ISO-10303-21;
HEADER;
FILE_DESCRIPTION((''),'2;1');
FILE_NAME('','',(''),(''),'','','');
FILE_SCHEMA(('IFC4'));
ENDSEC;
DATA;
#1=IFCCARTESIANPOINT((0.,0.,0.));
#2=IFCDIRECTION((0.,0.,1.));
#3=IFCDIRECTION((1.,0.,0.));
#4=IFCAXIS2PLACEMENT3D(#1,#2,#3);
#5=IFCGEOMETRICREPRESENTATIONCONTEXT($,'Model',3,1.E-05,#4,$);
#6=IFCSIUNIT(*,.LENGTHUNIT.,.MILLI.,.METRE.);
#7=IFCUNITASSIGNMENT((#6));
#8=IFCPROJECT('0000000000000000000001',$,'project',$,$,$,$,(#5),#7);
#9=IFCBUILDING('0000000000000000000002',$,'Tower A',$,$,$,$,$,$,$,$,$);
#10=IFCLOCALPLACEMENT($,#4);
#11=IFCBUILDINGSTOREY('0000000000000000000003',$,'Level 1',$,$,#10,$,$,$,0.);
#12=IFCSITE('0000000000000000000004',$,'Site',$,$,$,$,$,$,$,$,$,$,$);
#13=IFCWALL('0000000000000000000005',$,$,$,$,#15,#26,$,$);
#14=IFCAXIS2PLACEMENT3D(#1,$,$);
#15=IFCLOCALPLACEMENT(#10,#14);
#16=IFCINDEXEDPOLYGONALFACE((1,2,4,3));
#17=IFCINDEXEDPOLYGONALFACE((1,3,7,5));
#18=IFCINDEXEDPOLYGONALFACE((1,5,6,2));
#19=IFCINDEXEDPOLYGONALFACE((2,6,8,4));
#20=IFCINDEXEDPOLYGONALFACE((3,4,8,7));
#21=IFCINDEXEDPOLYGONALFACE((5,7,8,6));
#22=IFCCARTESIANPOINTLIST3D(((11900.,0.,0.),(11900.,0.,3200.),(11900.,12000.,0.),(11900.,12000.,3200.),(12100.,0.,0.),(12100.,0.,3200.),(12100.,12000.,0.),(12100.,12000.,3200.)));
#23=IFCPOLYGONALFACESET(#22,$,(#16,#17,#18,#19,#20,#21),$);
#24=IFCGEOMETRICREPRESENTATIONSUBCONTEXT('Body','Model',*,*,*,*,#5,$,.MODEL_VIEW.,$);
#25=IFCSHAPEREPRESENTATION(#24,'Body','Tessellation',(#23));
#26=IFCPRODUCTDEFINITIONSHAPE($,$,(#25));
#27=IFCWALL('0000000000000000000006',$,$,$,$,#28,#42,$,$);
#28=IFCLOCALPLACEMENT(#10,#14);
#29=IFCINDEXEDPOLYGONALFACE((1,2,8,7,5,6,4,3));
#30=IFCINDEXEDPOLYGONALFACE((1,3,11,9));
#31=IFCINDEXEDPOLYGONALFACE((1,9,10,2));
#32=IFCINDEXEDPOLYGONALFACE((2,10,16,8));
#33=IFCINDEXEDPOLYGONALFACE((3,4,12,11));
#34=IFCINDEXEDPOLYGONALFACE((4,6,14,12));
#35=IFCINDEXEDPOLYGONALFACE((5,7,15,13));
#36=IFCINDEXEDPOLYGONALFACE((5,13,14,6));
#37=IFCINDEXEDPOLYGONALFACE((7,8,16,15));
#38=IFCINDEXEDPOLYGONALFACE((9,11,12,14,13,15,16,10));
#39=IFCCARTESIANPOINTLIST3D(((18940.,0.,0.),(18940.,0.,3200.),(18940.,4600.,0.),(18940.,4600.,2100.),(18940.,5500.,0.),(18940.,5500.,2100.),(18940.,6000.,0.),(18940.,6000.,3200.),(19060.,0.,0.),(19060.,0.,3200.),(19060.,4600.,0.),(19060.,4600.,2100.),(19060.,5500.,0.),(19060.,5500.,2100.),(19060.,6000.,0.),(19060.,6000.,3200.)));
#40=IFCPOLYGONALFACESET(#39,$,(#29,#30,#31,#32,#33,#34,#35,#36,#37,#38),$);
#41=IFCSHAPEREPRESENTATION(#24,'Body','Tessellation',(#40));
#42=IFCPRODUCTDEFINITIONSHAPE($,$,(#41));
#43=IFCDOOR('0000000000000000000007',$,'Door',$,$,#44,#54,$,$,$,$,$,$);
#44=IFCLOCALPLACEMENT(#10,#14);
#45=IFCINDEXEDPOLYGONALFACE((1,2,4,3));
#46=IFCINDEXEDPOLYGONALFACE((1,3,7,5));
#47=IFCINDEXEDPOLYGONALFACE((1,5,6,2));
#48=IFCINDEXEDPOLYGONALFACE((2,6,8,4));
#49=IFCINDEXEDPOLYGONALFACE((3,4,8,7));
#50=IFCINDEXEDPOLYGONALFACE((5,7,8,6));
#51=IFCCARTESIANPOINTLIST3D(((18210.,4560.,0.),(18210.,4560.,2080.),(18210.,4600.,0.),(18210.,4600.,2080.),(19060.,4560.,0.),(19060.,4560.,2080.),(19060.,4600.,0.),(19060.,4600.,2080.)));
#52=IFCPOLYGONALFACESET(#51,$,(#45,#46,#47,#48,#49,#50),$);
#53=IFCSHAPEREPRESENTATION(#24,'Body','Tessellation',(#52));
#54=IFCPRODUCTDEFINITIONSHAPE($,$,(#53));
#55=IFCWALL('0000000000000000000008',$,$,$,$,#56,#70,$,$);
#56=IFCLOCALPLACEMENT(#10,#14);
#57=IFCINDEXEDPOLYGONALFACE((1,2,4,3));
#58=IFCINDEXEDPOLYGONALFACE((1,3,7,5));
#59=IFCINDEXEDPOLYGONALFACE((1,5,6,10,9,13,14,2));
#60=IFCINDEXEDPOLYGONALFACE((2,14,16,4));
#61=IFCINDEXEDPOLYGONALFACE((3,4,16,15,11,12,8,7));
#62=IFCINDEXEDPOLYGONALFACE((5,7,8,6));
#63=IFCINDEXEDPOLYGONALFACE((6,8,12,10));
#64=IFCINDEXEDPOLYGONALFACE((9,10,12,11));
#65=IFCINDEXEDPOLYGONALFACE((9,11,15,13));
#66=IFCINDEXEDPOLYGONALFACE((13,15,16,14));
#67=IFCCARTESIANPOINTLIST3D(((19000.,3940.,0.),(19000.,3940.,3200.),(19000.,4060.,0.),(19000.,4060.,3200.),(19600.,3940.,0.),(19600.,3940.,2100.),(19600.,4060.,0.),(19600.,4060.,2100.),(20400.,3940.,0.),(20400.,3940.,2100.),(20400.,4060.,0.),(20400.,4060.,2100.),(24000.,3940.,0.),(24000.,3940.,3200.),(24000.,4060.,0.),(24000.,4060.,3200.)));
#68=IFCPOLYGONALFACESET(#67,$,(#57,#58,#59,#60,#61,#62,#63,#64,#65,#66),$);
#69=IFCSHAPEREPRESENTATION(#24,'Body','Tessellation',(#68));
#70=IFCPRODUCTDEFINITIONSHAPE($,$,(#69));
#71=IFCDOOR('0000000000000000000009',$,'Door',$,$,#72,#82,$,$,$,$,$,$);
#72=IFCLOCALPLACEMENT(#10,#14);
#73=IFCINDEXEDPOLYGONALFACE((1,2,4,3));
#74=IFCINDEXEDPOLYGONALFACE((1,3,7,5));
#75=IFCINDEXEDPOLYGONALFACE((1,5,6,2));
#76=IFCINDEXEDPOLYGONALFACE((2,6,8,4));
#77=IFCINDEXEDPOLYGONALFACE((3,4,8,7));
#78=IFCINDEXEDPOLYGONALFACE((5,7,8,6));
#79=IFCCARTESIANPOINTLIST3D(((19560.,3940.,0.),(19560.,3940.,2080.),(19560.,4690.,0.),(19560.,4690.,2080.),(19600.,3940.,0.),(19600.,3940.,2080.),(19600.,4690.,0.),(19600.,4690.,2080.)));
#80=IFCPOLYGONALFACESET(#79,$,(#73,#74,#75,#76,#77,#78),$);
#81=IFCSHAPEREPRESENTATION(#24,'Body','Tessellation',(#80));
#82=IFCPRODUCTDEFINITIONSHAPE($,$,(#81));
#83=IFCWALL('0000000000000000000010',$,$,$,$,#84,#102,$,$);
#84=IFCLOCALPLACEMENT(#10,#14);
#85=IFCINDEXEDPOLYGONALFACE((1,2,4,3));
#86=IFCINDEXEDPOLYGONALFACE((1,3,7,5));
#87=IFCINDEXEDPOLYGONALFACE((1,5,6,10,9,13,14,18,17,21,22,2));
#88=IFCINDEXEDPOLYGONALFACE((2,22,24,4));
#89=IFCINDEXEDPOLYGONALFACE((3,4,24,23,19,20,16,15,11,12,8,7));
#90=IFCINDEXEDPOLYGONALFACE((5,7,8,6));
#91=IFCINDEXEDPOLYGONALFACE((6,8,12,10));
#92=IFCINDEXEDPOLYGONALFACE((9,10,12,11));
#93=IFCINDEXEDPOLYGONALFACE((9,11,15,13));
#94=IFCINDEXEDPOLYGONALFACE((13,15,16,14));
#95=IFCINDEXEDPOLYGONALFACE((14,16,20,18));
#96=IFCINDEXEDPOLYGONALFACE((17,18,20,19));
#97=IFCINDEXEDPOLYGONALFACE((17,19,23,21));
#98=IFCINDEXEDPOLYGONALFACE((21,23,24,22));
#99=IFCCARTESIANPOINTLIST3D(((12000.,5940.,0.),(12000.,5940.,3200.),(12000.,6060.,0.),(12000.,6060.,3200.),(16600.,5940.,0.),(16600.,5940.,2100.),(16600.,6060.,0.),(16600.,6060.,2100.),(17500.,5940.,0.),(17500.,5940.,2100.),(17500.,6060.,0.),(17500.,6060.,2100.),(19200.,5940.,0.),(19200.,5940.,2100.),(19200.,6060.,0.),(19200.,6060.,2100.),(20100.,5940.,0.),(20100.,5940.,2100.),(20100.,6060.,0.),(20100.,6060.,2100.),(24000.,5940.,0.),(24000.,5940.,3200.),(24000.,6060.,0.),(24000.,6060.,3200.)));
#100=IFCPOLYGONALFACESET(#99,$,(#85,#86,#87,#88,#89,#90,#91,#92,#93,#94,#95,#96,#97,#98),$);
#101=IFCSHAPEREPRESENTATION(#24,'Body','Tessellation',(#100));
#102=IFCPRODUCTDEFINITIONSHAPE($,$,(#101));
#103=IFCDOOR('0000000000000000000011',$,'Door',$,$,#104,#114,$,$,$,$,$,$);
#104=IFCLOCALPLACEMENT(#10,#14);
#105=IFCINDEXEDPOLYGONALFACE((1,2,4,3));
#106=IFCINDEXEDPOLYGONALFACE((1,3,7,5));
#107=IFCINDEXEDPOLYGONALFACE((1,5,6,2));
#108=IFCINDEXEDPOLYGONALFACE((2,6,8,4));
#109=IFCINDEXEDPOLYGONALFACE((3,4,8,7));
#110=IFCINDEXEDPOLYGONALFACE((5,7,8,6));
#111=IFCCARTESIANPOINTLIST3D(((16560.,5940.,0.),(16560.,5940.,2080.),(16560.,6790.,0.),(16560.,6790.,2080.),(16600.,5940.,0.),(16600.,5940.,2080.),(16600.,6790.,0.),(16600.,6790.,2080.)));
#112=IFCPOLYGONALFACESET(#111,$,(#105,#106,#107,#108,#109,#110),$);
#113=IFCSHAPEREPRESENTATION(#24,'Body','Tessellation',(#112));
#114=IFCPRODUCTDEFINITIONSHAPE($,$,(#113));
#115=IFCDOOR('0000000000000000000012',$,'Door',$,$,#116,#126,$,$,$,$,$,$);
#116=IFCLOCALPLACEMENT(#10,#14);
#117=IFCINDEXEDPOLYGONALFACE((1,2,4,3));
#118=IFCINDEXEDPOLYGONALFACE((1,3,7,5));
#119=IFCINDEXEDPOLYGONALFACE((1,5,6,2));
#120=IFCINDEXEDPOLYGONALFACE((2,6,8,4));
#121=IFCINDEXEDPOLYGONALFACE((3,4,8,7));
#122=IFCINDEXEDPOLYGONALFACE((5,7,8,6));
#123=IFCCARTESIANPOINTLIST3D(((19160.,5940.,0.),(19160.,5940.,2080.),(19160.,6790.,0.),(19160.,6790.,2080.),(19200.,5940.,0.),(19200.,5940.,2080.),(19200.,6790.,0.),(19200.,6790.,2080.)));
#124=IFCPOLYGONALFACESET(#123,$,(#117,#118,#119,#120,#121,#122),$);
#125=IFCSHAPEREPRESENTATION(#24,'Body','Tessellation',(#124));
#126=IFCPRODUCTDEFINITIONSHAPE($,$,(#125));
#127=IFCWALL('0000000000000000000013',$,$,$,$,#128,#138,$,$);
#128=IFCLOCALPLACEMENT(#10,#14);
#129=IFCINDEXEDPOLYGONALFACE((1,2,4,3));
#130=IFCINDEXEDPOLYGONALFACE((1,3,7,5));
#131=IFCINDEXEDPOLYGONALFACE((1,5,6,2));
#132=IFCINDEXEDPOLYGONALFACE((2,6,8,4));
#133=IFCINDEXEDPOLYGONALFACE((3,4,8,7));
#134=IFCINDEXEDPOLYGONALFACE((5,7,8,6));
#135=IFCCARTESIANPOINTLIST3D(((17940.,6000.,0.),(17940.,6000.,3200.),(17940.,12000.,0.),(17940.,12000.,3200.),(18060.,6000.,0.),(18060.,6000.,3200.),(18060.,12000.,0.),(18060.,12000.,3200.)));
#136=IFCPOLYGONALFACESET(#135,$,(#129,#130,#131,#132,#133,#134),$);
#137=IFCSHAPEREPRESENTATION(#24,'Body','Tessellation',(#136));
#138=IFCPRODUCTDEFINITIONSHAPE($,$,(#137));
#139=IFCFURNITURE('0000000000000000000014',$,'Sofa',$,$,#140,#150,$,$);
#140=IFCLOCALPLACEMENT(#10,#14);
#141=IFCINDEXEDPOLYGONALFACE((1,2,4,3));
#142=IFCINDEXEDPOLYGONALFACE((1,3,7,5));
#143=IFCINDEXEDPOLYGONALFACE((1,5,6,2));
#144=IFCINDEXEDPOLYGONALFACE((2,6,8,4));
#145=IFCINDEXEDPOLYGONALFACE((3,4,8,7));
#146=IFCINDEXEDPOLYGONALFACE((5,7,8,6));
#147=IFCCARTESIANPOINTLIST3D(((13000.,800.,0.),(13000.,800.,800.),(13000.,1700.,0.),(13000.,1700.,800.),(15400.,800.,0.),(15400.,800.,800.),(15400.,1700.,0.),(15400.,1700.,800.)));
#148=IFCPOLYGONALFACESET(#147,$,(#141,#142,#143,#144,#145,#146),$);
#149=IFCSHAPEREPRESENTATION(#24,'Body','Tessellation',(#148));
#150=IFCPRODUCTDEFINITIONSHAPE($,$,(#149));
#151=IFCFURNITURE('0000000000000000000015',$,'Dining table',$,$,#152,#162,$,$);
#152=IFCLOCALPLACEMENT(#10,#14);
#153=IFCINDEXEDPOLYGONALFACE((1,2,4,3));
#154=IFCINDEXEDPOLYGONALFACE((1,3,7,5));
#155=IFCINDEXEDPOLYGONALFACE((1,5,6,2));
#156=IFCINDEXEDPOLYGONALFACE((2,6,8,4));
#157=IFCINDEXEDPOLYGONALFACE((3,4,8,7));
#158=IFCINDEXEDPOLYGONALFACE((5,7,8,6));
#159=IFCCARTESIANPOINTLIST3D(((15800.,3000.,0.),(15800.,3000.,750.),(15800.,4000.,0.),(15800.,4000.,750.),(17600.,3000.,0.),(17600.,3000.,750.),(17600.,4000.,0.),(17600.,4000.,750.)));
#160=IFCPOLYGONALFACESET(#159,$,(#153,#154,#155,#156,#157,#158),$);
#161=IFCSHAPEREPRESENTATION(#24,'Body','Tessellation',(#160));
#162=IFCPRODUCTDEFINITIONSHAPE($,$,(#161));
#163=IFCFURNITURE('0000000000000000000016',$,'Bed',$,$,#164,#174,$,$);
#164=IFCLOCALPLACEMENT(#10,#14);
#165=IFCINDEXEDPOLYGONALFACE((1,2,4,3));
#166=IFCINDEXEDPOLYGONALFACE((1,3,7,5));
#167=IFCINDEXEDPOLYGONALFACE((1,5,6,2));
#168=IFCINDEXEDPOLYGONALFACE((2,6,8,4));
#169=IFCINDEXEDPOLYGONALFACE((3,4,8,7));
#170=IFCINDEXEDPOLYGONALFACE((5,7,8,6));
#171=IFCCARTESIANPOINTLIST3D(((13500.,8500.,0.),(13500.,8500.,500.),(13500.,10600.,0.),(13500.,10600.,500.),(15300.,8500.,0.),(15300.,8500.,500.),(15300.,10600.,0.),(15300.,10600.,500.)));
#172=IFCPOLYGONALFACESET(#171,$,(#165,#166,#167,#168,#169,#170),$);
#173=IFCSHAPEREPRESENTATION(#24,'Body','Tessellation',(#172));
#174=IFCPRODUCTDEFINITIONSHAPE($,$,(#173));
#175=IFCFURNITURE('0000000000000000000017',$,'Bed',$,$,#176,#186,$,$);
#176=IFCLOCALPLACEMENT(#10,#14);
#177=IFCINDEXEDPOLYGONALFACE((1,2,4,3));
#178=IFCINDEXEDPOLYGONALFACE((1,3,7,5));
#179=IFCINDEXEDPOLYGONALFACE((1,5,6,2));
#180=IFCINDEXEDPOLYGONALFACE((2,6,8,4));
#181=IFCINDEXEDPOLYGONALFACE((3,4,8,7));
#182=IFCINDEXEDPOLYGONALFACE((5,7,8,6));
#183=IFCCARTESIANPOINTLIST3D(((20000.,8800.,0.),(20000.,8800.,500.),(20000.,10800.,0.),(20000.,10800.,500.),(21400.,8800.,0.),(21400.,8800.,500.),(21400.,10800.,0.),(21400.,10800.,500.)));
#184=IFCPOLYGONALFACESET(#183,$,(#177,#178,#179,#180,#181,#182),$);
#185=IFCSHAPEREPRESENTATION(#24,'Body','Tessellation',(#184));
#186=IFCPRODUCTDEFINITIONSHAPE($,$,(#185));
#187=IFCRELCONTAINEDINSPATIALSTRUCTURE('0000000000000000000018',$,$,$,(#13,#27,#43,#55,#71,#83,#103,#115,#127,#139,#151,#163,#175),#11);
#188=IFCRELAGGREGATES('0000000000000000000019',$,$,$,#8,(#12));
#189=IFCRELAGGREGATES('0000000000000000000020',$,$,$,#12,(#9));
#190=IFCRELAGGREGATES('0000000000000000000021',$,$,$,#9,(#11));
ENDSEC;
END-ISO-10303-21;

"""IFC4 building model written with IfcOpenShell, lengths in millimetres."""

from ifc_helpers import new_model, si_unit, frame, origin_with_axes, place, context, subcontext, project, spatial, indexed_curve, outline, extrude, element, fill, save


model = new_model("IFC4")

# Units and contexts
model_context = context("Model", 3, precision=1e-05, world=origin_with_axes())
body_context = subcontext(model_context, "Body", "Model", "MODEL_VIEW")
ifc_project = project(units=[si_unit("LENGTHUNIT", "METRE", prefix="MILLI")], contexts=[model_context])

# Site, building, storey
site = spatial("IfcSite", under=ifc_project, Name="Site")
building = spatial("IfcBuilding", under=site, Name="Tower A")
storey_placement = place(None, origin_with_axes())
storey = spatial("IfcBuildingStorey", under=building, at=storey_placement, Name="Level 1", Elevation=0.0)

# Wall
wall_1_placement = place(storey_placement, frame((12100.0, 0.0, 0.0), z_axis=(0.0, 0.0, 1.0), x_axis=(0.0, 1.0, 0.0)))
element("IfcWall", 1, at=wall_1_placement, inside=storey, context=body_context, shape_type="SweptSolid", body=[
    extrude(outline(indexed_curve([(0.0, 0.0), (0.0, 200.0), (12000.0, 200.0), (12000.0, 0.0), (0.0, 0.0)], self_intersect=False)), origin_with_axes(), (0.0, 0.0, 1.0), 3200.0),
])

# Walls, openings, doors
wall_2_placement = place(storey_placement, frame((19060.0, 0.0, 0.0), z_axis=(0.0, 0.0, 1.0), x_axis=(0.0, 1.0, 0.0)))
wall_2 = element("IfcWall", 2, at=wall_2_placement, inside=storey, context=body_context, shape_type="SweptSolid", body=[
    extrude(outline(indexed_curve([(0.0, 0.0), (0.0, 120.0), (6000.0, 120.0), (6000.0, 0.0), (0.0, 0.0)], self_intersect=False)), origin_with_axes(), (0.0, 0.0, 1.0), 3200.0),
])
opening_1_placement = place(wall_2_placement, frame((4600.0, 0.0, 0.0), z_axis=(0.0, 0.0, 1.0), x_axis=(1.0, 0.0, 0.0)))
opening_1 = element("IfcOpeningElement", 3, at=opening_1_placement, cuts=wall_2, context=body_context, shape_type="SweptSolid", body=[
    extrude(outline(indexed_curve([(0.0, 0.0), (0.0, 120.0), (900.0, 120.0), (900.0, 0.0), (0.0, 0.0)], self_intersect=False)), origin_with_axes(), (0.0, 0.0, 1.0), 2100.0),
])
door_1_placement = place(storey_placement, frame((19060.0, 4600.0, 0.0), z_axis=(0.0, 0.0, 1.0), x_axis=(-1.0, 0.0, 0.0)))
door_1 = element("IfcDoor", 4, at=door_1_placement, inside=storey, Name="Door", context=body_context, shape_type="SweptSolid", body=[
    extrude(outline(indexed_curve([(0.0, 0.0), (0.0, 40.0), (850.0, 40.0), (850.0, 0.0), (0.0, 0.0)], self_intersect=False)), origin_with_axes(), (0.0, 0.0, 1.0), 2080.0),
])
fill(opening_1, door_1)
wall_3_placement = place(storey_placement, frame((19000.0, 3940.0, 0.0), z_axis=(0.0, 0.0, 1.0), x_axis=(1.0, 0.0, 0.0)))
wall_3 = element("IfcWall", 5, at=wall_3_placement, inside=storey, context=body_context, shape_type="SweptSolid", body=[
    extrude(outline(indexed_curve([(0.0, 0.0), (0.0, 120.0), (5000.0, 120.0), (5000.0, 0.0), (0.0, 0.0)], self_intersect=False)), origin_with_axes(), (0.0, 0.0, 1.0), 3200.0),
])
opening_2_placement = place(wall_3_placement, frame((600.0, 0.0, 0.0), z_axis=(0.0, 0.0, 1.0), x_axis=(1.0, 0.0, 0.0)))
opening_2 = element("IfcOpeningElement", 6, at=opening_2_placement, cuts=wall_3, context=body_context, shape_type="SweptSolid", body=[
    extrude(outline(indexed_curve([(0.0, 0.0), (0.0, 120.0), (800.0, 120.0), (800.0, 0.0), (0.0, 0.0)], self_intersect=False)), origin_with_axes(), (0.0, 0.0, 1.0), 2100.0),
])
door_2_placement = place(storey_placement, frame((19600.0, 3940.0, 0.0), z_axis=(0.0, 0.0, 1.0), x_axis=(0.0, 1.0, 0.0)))
door_2 = element("IfcDoor", 7, at=door_2_placement, inside=storey, Name="Door", context=body_context, shape_type="SweptSolid", body=[
    extrude(outline(indexed_curve([(0.0, 0.0), (0.0, 40.0), (750.0, 40.0), (750.0, 0.0), (0.0, 0.0)], self_intersect=False)), origin_with_axes(), (0.0, 0.0, 1.0), 2080.0),
])
fill(opening_2, door_2)

# Wall, openings, doors
wall_4_placement = place(storey_placement, frame((12000.0, 5940.0, 0.0), z_axis=(0.0, 0.0, 1.0), x_axis=(1.0, 0.0, 0.0)))
wall_4 = element("IfcWall", 8, at=wall_4_placement, inside=storey, context=body_context, shape_type="SweptSolid", body=[
    extrude(outline(indexed_curve([(0.0, 0.0), (0.0, 120.0), (12000.0, 120.0), (12000.0, 0.0), (0.0, 0.0)], self_intersect=False)), origin_with_axes(), (0.0, 0.0, 1.0), 3200.0),
])
opening_3_placement = place(wall_4_placement, frame((4600.0, 0.0, 0.0), z_axis=(0.0, 0.0, 1.0), x_axis=(1.0, 0.0, 0.0)))
opening_3 = element("IfcOpeningElement", 9, at=opening_3_placement, cuts=wall_4, context=body_context, shape_type="SweptSolid", body=[
    extrude(outline(indexed_curve([(0.0, 0.0), (0.0, 120.0), (900.0, 120.0), (900.0, 0.0), (0.0, 0.0)], self_intersect=False)), origin_with_axes(), (0.0, 0.0, 1.0), 2100.0),
])
opening_4_placement = place(wall_4_placement, frame((7200.0, 0.0, 0.0), z_axis=(0.0, 0.0, 1.0), x_axis=(1.0, 0.0, 0.0)))
opening_4 = element("IfcOpeningElement", 10, at=opening_4_placement, cuts=wall_4, context=body_context, shape_type="SweptSolid", body=[
    extrude(outline(indexed_curve([(0.0, 0.0), (0.0, 120.0), (900.0, 120.0), (900.0, 0.0), (0.0, 0.0)], self_intersect=False)), origin_with_axes(), (0.0, 0.0, 1.0), 2100.0),
])
door_3_placement = place(storey_placement, frame((16600.0, 5940.0, 0.0), z_axis=(0.0, 0.0, 1.0), x_axis=(0.0, 1.0, 0.0)))
door_3 = element("IfcDoor", 11, at=door_3_placement, inside=storey, Name="Door", context=body_context, shape_type="SweptSolid", body=[
    extrude(outline(indexed_curve([(0.0, 0.0), (0.0, 40.0), (850.0, 40.0), (850.0, 0.0), (0.0, 0.0)], self_intersect=False)), origin_with_axes(), (0.0, 0.0, 1.0), 2080.0),
])
fill(opening_3, door_3)
door_4_placement = place(storey_placement, frame((19200.0, 5940.0, 0.0), z_axis=(0.0, 0.0, 1.0), x_axis=(0.0, 1.0, 0.0)))
door_4 = element("IfcDoor", 12, at=door_4_placement, inside=storey, Name="Door", context=body_context, shape_type="SweptSolid", body=[
    extrude(outline(indexed_curve([(0.0, 0.0), (0.0, 40.0), (850.0, 40.0), (850.0, 0.0), (0.0, 0.0)], self_intersect=False)), origin_with_axes(), (0.0, 0.0, 1.0), 2080.0),
])
fill(opening_4, door_4)

# Wall
wall_5_placement = place(storey_placement, frame((18060.0, 6000.0, 0.0), z_axis=(0.0, 0.0, 1.0), x_axis=(0.0, 1.0, 0.0)))
element("IfcWall", 13, at=wall_5_placement, inside=storey, context=body_context, shape_type="SweptSolid", body=[
    extrude(outline(indexed_curve([(0.0, 0.0), (0.0, 120.0), (6000.0, 120.0), (6000.0, 0.0), (0.0, 0.0)], self_intersect=False)), origin_with_axes(), (0.0, 0.0, 1.0), 3200.0),
])

# Furniture
furniture_1_placement = place(storey_placement, frame((13000.0, 800.0, 0.0), z_axis=(0.0, 0.0, 1.0), x_axis=(1.0, 0.0, 0.0)))
element("IfcFurniture", 14, at=furniture_1_placement, inside=storey, Name="Sofa", context=body_context, shape_type="SweptSolid", body=[
    extrude(outline(indexed_curve([(0.0, 0.0), (2400.0, 0.0), (2400.0, 900.0), (0.0, 900.0)])), None, (0.0, 0.0, 1.0), 800.0),
])
furniture_2_placement = place(storey_placement, frame((15800.0, 3000.0, 0.0), z_axis=(0.0, 0.0, 1.0), x_axis=(1.0, 0.0, 0.0)))
element("IfcFurniture", 15, at=furniture_2_placement, inside=storey, Name="Dining table", context=body_context, shape_type="SweptSolid", body=[
    extrude(outline(indexed_curve([(0.0, 0.0), (1800.0, 0.0), (1800.0, 1000.0), (0.0, 1000.0)])), None, (0.0, 0.0, 1.0), 750.0),
])
furniture_3_placement = place(storey_placement, frame((13500.0, 8500.0, 0.0), z_axis=(0.0, 0.0, 1.0), x_axis=(1.0, 0.0, 0.0)))
element("IfcFurniture", 16, at=furniture_3_placement, inside=storey, Name="Bed", context=body_context, shape_type="SweptSolid", body=[
    extrude(outline(indexed_curve([(0.0, 0.0), (1800.0, 0.0), (1800.0, 2100.0), (0.0, 2100.0)])), None, (0.0, 0.0, 1.0), 500.0),
])
furniture_4_placement = place(storey_placement, frame((20000.0, 8800.0, 0.0), z_axis=(0.0, 0.0, 1.0), x_axis=(1.0, 0.0, 0.0)))
element("IfcFurniture", 17, at=furniture_4_placement, inside=storey, Name="Bed", context=body_context, shape_type="SweptSolid", body=[
    extrude(outline(indexed_curve([(0.0, 0.0), (1400.0, 0.0), (1400.0, 2000.0), (0.0, 2000.0)])), None, (0.0, 0.0, 1.0), 500.0),
])

save(model, "model.ifc")
